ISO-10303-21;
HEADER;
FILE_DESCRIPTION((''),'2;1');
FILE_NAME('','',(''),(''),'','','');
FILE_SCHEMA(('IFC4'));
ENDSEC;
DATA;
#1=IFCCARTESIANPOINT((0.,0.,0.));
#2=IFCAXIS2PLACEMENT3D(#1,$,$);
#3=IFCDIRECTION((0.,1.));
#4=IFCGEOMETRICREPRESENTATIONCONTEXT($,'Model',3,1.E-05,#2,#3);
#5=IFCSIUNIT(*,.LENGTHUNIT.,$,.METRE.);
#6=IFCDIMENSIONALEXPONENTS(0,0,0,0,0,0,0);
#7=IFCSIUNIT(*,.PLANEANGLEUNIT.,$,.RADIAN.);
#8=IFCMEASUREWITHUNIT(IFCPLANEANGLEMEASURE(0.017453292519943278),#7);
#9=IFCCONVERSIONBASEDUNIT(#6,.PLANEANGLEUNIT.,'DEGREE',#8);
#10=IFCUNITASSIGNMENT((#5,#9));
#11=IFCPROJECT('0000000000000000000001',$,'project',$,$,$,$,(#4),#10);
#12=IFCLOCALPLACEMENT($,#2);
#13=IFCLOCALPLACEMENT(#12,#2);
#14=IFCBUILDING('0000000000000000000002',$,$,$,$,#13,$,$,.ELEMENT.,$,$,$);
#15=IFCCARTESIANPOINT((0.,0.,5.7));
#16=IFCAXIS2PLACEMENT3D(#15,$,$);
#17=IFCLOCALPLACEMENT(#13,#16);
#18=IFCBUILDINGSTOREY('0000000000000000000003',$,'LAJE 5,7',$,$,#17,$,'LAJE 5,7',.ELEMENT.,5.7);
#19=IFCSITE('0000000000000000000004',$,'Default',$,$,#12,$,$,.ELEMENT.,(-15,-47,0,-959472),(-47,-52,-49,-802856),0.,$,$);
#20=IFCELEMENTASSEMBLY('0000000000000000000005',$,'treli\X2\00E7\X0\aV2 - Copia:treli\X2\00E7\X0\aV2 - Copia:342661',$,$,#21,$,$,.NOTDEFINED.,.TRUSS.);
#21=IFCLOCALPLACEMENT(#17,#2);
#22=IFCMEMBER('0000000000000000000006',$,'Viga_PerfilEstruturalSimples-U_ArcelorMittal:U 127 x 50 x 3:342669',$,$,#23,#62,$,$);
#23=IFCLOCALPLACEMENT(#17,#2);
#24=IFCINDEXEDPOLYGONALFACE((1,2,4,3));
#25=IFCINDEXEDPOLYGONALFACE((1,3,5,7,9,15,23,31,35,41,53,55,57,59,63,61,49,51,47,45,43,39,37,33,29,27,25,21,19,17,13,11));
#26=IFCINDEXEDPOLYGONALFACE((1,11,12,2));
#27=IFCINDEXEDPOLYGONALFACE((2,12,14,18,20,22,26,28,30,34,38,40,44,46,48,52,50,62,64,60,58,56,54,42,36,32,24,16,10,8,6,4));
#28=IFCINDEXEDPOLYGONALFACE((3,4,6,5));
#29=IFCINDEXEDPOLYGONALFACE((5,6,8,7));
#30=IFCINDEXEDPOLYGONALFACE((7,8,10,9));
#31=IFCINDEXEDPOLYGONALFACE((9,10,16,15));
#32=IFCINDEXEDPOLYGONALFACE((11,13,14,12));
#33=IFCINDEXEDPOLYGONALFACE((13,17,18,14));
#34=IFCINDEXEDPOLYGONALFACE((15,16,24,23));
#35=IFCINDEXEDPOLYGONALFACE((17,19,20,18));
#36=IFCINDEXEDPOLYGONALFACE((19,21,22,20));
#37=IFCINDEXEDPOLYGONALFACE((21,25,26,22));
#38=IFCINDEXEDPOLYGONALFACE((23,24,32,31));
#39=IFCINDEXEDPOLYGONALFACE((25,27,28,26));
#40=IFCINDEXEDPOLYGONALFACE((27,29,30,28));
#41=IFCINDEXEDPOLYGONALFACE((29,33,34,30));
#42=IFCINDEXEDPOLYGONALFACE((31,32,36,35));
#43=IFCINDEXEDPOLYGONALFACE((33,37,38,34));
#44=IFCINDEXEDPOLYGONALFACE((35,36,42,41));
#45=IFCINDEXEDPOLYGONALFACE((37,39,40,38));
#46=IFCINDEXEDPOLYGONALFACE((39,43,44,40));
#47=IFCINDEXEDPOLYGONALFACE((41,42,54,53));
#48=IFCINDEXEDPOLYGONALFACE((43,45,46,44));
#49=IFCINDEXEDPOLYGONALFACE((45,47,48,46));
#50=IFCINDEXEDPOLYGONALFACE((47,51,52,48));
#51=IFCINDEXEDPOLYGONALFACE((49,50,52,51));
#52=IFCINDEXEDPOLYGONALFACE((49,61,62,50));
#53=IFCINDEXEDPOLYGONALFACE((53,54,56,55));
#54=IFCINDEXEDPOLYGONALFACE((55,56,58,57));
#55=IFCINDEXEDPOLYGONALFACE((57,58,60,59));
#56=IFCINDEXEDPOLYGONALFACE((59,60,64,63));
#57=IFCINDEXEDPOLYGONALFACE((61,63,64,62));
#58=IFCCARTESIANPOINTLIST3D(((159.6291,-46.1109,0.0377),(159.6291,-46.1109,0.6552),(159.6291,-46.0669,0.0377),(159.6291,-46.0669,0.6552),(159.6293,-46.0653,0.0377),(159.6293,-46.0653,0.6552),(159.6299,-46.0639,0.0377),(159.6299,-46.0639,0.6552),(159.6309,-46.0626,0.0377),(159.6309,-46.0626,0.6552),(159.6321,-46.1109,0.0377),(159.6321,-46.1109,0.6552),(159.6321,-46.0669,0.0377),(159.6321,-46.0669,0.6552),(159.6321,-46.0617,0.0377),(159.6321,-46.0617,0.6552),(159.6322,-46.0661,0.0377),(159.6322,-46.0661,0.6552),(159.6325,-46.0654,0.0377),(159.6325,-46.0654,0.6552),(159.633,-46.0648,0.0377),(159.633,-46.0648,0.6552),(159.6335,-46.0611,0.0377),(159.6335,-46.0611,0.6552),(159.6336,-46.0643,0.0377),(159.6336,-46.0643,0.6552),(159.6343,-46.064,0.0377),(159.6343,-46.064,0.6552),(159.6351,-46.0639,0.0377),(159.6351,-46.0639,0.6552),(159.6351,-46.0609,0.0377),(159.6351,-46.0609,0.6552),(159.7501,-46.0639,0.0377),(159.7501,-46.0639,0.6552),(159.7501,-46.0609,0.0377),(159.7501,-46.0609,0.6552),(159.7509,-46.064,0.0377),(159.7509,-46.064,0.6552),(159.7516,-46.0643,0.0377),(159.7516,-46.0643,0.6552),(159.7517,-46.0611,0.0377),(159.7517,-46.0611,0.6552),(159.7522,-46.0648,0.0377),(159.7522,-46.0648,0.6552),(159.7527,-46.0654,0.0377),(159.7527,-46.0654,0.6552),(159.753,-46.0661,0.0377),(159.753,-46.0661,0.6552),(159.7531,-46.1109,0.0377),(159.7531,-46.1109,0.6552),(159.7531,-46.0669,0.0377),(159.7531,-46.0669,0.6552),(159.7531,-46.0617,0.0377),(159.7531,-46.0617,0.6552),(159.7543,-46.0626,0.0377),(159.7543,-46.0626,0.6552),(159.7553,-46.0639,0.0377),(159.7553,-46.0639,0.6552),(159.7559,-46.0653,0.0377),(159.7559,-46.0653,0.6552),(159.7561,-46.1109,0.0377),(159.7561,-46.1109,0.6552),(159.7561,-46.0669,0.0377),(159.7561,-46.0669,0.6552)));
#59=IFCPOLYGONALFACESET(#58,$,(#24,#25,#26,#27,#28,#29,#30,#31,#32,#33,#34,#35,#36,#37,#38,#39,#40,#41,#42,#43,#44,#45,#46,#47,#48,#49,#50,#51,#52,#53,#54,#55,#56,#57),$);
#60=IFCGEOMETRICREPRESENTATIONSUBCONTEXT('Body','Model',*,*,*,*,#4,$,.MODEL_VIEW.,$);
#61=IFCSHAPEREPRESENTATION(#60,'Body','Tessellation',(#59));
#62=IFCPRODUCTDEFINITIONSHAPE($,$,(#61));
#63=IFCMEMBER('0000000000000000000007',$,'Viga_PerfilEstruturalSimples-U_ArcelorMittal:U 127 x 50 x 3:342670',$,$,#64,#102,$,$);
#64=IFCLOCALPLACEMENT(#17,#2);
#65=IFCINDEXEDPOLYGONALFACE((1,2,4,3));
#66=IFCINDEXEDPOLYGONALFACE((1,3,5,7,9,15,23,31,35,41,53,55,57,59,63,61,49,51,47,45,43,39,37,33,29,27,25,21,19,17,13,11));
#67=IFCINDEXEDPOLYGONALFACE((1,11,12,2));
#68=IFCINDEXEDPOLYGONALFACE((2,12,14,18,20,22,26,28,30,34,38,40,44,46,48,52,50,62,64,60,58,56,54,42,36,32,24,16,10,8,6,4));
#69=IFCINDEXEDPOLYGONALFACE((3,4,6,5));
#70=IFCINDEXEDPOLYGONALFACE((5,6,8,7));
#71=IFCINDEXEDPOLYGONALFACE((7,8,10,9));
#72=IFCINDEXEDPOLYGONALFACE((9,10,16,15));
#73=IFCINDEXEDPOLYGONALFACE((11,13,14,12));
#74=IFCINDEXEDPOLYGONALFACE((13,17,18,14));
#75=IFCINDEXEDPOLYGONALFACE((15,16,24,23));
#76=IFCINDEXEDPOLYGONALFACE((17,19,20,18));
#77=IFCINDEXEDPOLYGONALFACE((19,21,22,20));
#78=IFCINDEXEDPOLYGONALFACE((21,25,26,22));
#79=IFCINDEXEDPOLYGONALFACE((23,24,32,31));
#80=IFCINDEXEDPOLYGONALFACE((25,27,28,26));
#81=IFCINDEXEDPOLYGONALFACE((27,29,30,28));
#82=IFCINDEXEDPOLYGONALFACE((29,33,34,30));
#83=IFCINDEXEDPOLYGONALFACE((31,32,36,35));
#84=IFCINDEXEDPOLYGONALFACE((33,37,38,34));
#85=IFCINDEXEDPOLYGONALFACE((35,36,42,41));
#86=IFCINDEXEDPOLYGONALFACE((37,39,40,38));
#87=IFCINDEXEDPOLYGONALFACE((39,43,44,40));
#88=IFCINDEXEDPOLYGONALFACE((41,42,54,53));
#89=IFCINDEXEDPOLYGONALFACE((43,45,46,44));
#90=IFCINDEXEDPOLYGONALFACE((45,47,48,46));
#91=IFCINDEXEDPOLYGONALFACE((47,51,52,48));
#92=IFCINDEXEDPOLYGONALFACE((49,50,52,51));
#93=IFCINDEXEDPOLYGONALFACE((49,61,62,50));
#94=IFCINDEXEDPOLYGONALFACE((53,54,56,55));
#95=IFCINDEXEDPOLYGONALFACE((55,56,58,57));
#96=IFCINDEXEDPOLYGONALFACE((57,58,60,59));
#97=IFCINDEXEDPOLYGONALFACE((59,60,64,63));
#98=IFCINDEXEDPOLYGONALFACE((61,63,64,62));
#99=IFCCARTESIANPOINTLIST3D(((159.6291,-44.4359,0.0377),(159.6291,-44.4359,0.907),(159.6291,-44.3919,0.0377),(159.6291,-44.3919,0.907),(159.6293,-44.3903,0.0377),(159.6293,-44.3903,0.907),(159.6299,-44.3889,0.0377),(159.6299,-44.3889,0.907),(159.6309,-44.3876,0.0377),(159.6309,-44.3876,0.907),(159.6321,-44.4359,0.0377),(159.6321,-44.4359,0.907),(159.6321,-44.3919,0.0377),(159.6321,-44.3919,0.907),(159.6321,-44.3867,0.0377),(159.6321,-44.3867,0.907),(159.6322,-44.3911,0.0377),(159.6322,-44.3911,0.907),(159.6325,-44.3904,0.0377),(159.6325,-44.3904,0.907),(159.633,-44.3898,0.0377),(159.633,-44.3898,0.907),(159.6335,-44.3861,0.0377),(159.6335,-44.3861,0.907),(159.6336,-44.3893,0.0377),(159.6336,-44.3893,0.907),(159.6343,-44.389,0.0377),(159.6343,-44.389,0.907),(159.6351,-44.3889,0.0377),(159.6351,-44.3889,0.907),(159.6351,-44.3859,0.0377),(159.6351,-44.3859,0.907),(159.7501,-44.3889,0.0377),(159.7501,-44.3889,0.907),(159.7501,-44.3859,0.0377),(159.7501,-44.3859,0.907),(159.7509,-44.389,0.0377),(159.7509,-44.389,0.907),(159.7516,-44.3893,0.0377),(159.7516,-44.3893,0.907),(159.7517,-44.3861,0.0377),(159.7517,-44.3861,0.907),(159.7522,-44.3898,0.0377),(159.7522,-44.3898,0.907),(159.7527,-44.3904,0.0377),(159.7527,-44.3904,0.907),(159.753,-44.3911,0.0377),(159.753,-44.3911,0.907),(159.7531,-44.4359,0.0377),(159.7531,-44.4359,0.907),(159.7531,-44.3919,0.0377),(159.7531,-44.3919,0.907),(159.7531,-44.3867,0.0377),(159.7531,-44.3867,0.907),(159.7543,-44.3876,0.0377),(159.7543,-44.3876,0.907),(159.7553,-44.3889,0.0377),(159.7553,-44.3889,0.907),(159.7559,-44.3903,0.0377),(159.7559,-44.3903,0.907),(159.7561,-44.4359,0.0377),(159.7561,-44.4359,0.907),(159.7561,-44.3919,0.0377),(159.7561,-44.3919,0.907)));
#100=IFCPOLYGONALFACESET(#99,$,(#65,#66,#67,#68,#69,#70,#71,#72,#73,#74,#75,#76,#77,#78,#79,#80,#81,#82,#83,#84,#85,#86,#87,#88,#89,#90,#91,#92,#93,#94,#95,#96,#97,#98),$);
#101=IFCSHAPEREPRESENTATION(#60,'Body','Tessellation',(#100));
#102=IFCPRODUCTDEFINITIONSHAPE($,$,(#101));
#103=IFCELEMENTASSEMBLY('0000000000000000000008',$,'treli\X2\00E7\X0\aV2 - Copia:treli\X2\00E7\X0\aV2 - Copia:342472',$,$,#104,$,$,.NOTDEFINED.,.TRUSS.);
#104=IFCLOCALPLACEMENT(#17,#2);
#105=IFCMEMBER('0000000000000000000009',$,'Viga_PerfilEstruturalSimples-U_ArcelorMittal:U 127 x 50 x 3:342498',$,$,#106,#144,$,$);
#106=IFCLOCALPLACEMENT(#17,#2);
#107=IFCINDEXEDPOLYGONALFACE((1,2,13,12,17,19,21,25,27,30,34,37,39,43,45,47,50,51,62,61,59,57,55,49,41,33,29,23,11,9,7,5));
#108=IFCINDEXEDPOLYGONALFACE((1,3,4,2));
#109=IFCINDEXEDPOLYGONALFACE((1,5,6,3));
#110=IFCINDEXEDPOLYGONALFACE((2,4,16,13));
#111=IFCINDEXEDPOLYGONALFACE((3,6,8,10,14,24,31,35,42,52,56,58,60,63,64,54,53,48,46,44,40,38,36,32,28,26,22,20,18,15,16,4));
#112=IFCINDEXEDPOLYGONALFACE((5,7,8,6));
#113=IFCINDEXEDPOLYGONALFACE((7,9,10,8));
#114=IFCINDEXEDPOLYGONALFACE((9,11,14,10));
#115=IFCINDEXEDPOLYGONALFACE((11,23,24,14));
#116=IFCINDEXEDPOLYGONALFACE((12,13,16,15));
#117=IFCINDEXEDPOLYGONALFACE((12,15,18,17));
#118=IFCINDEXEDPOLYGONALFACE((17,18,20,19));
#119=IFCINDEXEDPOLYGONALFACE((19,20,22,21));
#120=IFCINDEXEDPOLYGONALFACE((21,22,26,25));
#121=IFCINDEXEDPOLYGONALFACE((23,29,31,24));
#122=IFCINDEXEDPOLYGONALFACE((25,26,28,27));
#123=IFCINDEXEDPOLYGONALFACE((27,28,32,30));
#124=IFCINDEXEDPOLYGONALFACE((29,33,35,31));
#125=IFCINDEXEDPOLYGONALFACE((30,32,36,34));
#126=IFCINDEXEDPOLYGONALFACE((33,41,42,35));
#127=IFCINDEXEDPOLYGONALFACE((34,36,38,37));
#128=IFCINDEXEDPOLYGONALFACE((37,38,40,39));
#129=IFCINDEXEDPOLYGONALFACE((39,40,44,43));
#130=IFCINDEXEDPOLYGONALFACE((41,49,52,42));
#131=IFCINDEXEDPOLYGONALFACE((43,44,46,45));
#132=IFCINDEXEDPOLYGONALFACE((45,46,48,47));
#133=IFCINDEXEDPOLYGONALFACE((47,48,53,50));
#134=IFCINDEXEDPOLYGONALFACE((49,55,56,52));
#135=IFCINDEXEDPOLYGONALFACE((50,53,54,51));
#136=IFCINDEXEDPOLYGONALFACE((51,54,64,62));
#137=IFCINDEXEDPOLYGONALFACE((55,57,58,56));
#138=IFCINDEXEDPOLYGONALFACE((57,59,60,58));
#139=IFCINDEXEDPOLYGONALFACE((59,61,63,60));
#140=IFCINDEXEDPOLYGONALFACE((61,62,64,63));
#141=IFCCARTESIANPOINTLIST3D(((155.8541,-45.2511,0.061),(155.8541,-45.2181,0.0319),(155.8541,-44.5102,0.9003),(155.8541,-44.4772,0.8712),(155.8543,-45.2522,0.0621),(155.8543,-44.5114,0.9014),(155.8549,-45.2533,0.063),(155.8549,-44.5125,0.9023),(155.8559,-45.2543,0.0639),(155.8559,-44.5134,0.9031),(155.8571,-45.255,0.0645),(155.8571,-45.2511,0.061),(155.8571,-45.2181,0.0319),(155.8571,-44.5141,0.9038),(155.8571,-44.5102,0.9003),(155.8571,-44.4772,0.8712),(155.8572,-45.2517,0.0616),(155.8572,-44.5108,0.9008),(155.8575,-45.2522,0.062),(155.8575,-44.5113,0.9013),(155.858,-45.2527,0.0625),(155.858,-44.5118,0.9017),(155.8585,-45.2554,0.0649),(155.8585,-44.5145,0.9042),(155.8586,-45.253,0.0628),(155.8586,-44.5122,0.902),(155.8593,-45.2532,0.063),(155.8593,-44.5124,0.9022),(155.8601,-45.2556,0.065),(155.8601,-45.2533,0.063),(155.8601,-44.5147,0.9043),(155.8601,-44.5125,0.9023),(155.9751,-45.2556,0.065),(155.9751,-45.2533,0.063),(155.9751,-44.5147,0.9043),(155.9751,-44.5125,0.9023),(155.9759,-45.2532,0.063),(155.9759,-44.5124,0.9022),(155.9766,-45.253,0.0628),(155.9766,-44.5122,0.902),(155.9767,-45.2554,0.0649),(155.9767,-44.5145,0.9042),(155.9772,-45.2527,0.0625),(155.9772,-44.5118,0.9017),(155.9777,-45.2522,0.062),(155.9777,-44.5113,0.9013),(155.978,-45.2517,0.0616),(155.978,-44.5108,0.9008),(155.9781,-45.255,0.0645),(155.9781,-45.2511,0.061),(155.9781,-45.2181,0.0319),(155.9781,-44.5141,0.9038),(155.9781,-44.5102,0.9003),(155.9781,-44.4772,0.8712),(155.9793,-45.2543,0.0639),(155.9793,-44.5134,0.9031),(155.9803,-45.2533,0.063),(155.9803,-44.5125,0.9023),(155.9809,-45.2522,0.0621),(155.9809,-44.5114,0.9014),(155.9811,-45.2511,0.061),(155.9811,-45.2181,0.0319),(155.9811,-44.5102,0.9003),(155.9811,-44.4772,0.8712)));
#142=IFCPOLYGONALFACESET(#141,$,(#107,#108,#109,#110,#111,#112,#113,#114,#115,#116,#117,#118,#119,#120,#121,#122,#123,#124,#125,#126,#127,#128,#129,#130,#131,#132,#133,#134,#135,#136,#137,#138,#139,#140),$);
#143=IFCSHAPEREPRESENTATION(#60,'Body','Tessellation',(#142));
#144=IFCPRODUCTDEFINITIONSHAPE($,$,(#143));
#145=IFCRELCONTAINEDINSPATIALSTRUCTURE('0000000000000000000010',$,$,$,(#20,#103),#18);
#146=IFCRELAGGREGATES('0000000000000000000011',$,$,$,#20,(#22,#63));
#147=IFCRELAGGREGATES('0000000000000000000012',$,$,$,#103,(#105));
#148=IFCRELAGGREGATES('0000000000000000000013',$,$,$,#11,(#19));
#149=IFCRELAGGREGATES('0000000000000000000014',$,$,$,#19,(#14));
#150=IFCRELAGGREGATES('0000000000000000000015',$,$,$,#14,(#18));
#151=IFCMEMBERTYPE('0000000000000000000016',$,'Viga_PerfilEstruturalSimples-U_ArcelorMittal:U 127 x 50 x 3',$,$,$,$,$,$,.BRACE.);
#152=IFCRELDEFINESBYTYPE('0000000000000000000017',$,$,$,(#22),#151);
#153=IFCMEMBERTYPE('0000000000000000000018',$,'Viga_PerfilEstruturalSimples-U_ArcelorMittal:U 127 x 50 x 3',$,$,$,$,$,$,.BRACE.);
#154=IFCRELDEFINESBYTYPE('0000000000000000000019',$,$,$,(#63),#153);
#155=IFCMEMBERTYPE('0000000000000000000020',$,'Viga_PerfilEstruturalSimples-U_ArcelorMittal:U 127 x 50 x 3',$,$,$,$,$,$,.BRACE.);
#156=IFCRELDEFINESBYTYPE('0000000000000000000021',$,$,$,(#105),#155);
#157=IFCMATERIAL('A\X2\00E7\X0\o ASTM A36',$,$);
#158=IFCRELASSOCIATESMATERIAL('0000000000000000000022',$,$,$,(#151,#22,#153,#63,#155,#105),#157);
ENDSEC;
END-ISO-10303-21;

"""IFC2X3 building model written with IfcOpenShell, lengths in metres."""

from ifc_helpers import new_model, entity, si_unit, converted_unit, direction, frame, frame_2d, origin, place, context, subcontext, project, spatial, polyline, circle_curve, parameter, trimmed, segment, composite_curve, outline, extrude, source, transform, mapped, material, type_object, type_shapes, element, aggregate, save


model = new_model("IFC2X3")

# Units and contexts
model_context = context("Model", 3, precision=1e-05, world=origin(), true_north=direction((0.0, 1.0)))
body_context = subcontext(model_context, "Body", "Model", "MODEL_VIEW")
ifc_project = project(units=[si_unit("LENGTHUNIT", "METRE"), converted_unit("PLANEANGLEUNIT", "DEGREE", entity("IfcPlaneAngleMeasure", 0.017453292519943278), si_unit("PLANEANGLEUNIT", "RADIAN"), dimensions=[0, 0, 0, 0, 0, 0, 0])], contexts=[model_context])

# Site, building, storey
site_placement = place(None, origin())
site = spatial("IfcSite", under=ifc_project, at=site_placement, Name="Default", CompositionType="ELEMENT", RefLatitude=(-15, -47, 0, -959472), RefLongitude=(-47, -52, -49, -802856), RefElevation=0.0)
building_placement = place(site_placement, origin())
building = spatial("IfcBuilding", under=site, at=building_placement, CompositionType="ELEMENT")
storey_placement = place(building_placement, frame((0.0, 0.0, 5.7)))
storey = spatial("IfcBuildingStorey", under=building, at=storey_placement, Name="LAJE 5,7", LongName="LAJE 5,7", CompositionType="ELEMENT", Elevation=5.7)

# Element assemblies, members
assembly_1_placement = place(storey_placement, origin())
assembly_1 = element("IfcElementAssembly", 1, at=assembly_1_placement, inside=storey, Name="treliçaV2 - Copia:treliçaV2 - Copia:342661", AssemblyPlace="NOTDEFINED", PredefinedType="TRUSS")
ifc_material = material(Name="Aço ASTM A36")
member_type_1 = type_object("IfcMemberType", Name="Viga_PerfilEstruturalSimples-U_ArcelorMittal:U 127 x 50 x 3", PredefinedType="BRACE", material=ifc_material)
shared_shape_1 = source(origin(), body_context, "Body", "SweptSolid", [
    extrude(outline(composite_curve([segment(polyline([(-0.0575, -0.0192), (0.0575, -0.0192)]), True, "CONTINUOUS"), segment(trimmed(circle_curve(frame_2d((0.0575, -0.0132), x_axis=(0.0, 1.0)), 0.006), [parameter(180.0)], [parameter(270.0)], True, "PARAMETER"), True, "CONTINUOUS"), segment(polyline([(0.0635, -0.0132), (0.0635, 0.0308)]), True, "CONTINUOUS"), segment(polyline([(0.0635, 0.0308), (0.0605, 0.0308)]), True, "CONTINUOUS"), segment(polyline([(0.0605, 0.0308), (0.0605, -0.0132)]), True, "CONTINUOUS"), segment(trimmed(circle_curve(frame_2d((0.0575, -0.0132), x_axis=(0.0, 1.0)), 0.003), [parameter(180.0)], [parameter(270.0)], True, "PARAMETER"), False, "CONTINUOUS"), segment(polyline([(0.0575, -0.0162), (-0.0575, -0.0162)]), True, "CONTINUOUS"), segment(trimmed(circle_curve(frame_2d((-0.0575, -0.0132), x_axis=(0.0, 1.0)), 0.003), [parameter(90.0)], [parameter(180.0)], True, "PARAMETER"), False, "CONTINUOUS"), segment(polyline([(-0.0605, -0.0132), (-0.0605, 0.0308)]), True, "CONTINUOUS"), segment(polyline([(-0.0605, 0.0308), (-0.0635, 0.0308)]), True, "CONTINUOUS"), segment(polyline([(-0.0635, 0.0308), (-0.0635, -0.0132)]), True, "CONTINUOUS"), segment(trimmed(circle_curve(frame_2d((-0.0575, -0.0132), x_axis=(0.0, 1.0)), 0.006), [parameter(90.0)], [parameter(180.0)], True, "PARAMETER"), True, "CONTINUOUS")], self_intersect=False)), frame((-0.3108, -0.0058, 0.0), z_axis=(1.0, 0.0, 0.0), x_axis=(0.0, 0.0, -1.0)), (0.0, 0.0, 1.0), 0.6175),
])
type_shapes(member_type_1, [shared_shape_1])
member_1_placement = place(assembly_1_placement, frame((159.6926, -46.0859, 0.3485), z_axis=(1.0, 0.0, 0.0), x_axis=(0.0, 0.0, 1.0)))
member_1 = element("IfcMember", 2, at=member_1_placement, type_object=member_type_1, material=ifc_material, Name="Viga_PerfilEstruturalSimples-U_ArcelorMittal:U 127 x 50 x 3:342669", context=body_context, shape_type="MappedRepresentation", body=[
    mapped(shared_shape_1, transform((0.0, 0.0, 0.0), scale=1.0)),
])
member_type_2 = type_object("IfcMemberType", Name="Viga_PerfilEstruturalSimples-U_ArcelorMittal:U 127 x 50 x 3", PredefinedType="BRACE", material=ifc_material)
shared_shape_2 = source(origin(), body_context, "Body", "SweptSolid", [
    extrude(outline(composite_curve([segment(polyline([(-0.0575, -0.0192), (0.0575, -0.0192)]), True, "CONTINUOUS"), segment(trimmed(circle_curve(frame_2d((0.0575, -0.0132), x_axis=(0.0, 1.0)), 0.006), [parameter(180.0)], [parameter(270.0)], True, "PARAMETER"), True, "CONTINUOUS"), segment(polyline([(0.0635, -0.0132), (0.0635, 0.0308)]), True, "CONTINUOUS"), segment(polyline([(0.0635, 0.0308), (0.0605, 0.0308)]), True, "CONTINUOUS"), segment(polyline([(0.0605, 0.0308), (0.0605, -0.0132)]), True, "CONTINUOUS"), segment(trimmed(circle_curve(frame_2d((0.0575, -0.0132), x_axis=(0.0, 1.0)), 0.003), [parameter(180.0)], [parameter(270.0)], True, "PARAMETER"), False, "CONTINUOUS"), segment(polyline([(0.0575, -0.0162), (-0.0575, -0.0162)]), True, "CONTINUOUS"), segment(trimmed(circle_curve(frame_2d((-0.0575, -0.0132), x_axis=(0.0, 1.0)), 0.003), [parameter(90.0)], [parameter(180.0)], True, "PARAMETER"), False, "CONTINUOUS"), segment(polyline([(-0.0605, -0.0132), (-0.0605, 0.0308)]), True, "CONTINUOUS"), segment(polyline([(-0.0605, 0.0308), (-0.0635, 0.0308)]), True, "CONTINUOUS"), segment(polyline([(-0.0635, 0.0308), (-0.0635, -0.0132)]), True, "CONTINUOUS"), segment(trimmed(circle_curve(frame_2d((-0.0575, -0.0132), x_axis=(0.0, 1.0)), 0.006), [parameter(90.0)], [parameter(180.0)], True, "PARAMETER"), True, "CONTINUOUS")], self_intersect=False)), frame((-0.4367, -0.0058, 0.0), z_axis=(1.0, 0.0, 0.0), x_axis=(0.0, 0.0, -1.0)), (0.0, 0.0, 1.0), 0.8693),
])
type_shapes(member_type_2, [shared_shape_2])
member_2_placement = place(assembly_1_placement, frame((159.6926, -44.4109, 0.4744), z_axis=(1.0, 0.0, 0.0), x_axis=(0.0, 0.0, 1.0)))
member_2 = element("IfcMember", 3, at=member_2_placement, type_object=member_type_2, material=ifc_material, Name="Viga_PerfilEstruturalSimples-U_ArcelorMittal:U 127 x 50 x 3:342670", context=body_context, shape_type="MappedRepresentation", body=[
    mapped(shared_shape_2, transform((0.0, 0.0, 0.0), scale=1.0)),
])
aggregate(assembly_1, [member_1, member_2])
assembly_2_placement = place(storey_placement, origin())
assembly_2 = element("IfcElementAssembly", 4, at=assembly_2_placement, inside=storey, Name="treliçaV2 - Copia:treliçaV2 - Copia:342472", AssemblyPlace="NOTDEFINED", PredefinedType="TRUSS")
member_type_3 = type_object("IfcMemberType", Name="Viga_PerfilEstruturalSimples-U_ArcelorMittal:U 127 x 50 x 3", PredefinedType="BRACE", material=ifc_material)
shared_shape_3 = source(origin(), body_context, "Body", "SweptSolid", [
    extrude(outline(composite_curve([segment(polyline([(-0.0575, -0.0192), (0.0575, -0.0192)]), True, "CONTINUOUS"), segment(trimmed(circle_curve(frame_2d((0.0575, -0.0132), x_axis=(0.0, 1.0)), 0.006), [parameter(180.0)], [parameter(270.0)], True, "PARAMETER"), True, "CONTINUOUS"), segment(polyline([(0.0635, -0.0132), (0.0635, 0.0308)]), True, "CONTINUOUS"), segment(polyline([(0.0635, 0.0308), (0.0605, 0.0308)]), True, "CONTINUOUS"), segment(polyline([(0.0605, 0.0308), (0.0605, -0.0132)]), True, "CONTINUOUS"), segment(trimmed(circle_curve(frame_2d((0.0575, -0.0132), x_axis=(0.0, 1.0)), 0.003), [parameter(180.0)], [parameter(270.0)], True, "PARAMETER"), False, "CONTINUOUS"), segment(polyline([(0.0575, -0.0162), (-0.0575, -0.0162)]), True, "CONTINUOUS"), segment(trimmed(circle_curve(frame_2d((-0.0575, -0.0132), x_axis=(0.0, 1.0)), 0.003), [parameter(90.0)], [parameter(180.0)], True, "PARAMETER"), False, "CONTINUOUS"), segment(polyline([(-0.0605, -0.0132), (-0.0605, 0.0308)]), True, "CONTINUOUS"), segment(polyline([(-0.0605, 0.0308), (-0.0635, 0.0308)]), True, "CONTINUOUS"), segment(polyline([(-0.0635, 0.0308), (-0.0635, -0.0132)]), True, "CONTINUOUS"), segment(trimmed(circle_curve(frame_2d((-0.0575, -0.0132), x_axis=(0.0, 1.0)), 0.006), [parameter(90.0)], [parameter(180.0)], True, "PARAMETER"), True, "CONTINUOUS")], self_intersect=False)), frame((-0.5681, -0.0058, 0.0), z_axis=(1.0, 0.0, 0.0), x_axis=(0.0, 0.0, -1.0)), (0.0, 0.0, 1.0), 1.1195),
])
type_shapes(member_type_3, [shared_shape_3])
member_3_placement = place(assembly_2_placement, frame((155.9176, -44.8609, 0.4744), z_axis=(-1.0, 0.0, 0.0), x_axis=(0.0, 0.661783, 0.749695)))
member_3 = element("IfcMember", 5, at=member_3_placement, type_object=member_type_3, material=ifc_material, Name="Viga_PerfilEstruturalSimples-U_ArcelorMittal:U 127 x 50 x 3:342498", context=body_context, shape_type="MappedRepresentation", body=[
    mapped(shared_shape_3, transform((0.0, 0.0, 0.0), scale=1.0)),
])
aggregate(assembly_2, [member_3])

save(model, "model.ifc")
